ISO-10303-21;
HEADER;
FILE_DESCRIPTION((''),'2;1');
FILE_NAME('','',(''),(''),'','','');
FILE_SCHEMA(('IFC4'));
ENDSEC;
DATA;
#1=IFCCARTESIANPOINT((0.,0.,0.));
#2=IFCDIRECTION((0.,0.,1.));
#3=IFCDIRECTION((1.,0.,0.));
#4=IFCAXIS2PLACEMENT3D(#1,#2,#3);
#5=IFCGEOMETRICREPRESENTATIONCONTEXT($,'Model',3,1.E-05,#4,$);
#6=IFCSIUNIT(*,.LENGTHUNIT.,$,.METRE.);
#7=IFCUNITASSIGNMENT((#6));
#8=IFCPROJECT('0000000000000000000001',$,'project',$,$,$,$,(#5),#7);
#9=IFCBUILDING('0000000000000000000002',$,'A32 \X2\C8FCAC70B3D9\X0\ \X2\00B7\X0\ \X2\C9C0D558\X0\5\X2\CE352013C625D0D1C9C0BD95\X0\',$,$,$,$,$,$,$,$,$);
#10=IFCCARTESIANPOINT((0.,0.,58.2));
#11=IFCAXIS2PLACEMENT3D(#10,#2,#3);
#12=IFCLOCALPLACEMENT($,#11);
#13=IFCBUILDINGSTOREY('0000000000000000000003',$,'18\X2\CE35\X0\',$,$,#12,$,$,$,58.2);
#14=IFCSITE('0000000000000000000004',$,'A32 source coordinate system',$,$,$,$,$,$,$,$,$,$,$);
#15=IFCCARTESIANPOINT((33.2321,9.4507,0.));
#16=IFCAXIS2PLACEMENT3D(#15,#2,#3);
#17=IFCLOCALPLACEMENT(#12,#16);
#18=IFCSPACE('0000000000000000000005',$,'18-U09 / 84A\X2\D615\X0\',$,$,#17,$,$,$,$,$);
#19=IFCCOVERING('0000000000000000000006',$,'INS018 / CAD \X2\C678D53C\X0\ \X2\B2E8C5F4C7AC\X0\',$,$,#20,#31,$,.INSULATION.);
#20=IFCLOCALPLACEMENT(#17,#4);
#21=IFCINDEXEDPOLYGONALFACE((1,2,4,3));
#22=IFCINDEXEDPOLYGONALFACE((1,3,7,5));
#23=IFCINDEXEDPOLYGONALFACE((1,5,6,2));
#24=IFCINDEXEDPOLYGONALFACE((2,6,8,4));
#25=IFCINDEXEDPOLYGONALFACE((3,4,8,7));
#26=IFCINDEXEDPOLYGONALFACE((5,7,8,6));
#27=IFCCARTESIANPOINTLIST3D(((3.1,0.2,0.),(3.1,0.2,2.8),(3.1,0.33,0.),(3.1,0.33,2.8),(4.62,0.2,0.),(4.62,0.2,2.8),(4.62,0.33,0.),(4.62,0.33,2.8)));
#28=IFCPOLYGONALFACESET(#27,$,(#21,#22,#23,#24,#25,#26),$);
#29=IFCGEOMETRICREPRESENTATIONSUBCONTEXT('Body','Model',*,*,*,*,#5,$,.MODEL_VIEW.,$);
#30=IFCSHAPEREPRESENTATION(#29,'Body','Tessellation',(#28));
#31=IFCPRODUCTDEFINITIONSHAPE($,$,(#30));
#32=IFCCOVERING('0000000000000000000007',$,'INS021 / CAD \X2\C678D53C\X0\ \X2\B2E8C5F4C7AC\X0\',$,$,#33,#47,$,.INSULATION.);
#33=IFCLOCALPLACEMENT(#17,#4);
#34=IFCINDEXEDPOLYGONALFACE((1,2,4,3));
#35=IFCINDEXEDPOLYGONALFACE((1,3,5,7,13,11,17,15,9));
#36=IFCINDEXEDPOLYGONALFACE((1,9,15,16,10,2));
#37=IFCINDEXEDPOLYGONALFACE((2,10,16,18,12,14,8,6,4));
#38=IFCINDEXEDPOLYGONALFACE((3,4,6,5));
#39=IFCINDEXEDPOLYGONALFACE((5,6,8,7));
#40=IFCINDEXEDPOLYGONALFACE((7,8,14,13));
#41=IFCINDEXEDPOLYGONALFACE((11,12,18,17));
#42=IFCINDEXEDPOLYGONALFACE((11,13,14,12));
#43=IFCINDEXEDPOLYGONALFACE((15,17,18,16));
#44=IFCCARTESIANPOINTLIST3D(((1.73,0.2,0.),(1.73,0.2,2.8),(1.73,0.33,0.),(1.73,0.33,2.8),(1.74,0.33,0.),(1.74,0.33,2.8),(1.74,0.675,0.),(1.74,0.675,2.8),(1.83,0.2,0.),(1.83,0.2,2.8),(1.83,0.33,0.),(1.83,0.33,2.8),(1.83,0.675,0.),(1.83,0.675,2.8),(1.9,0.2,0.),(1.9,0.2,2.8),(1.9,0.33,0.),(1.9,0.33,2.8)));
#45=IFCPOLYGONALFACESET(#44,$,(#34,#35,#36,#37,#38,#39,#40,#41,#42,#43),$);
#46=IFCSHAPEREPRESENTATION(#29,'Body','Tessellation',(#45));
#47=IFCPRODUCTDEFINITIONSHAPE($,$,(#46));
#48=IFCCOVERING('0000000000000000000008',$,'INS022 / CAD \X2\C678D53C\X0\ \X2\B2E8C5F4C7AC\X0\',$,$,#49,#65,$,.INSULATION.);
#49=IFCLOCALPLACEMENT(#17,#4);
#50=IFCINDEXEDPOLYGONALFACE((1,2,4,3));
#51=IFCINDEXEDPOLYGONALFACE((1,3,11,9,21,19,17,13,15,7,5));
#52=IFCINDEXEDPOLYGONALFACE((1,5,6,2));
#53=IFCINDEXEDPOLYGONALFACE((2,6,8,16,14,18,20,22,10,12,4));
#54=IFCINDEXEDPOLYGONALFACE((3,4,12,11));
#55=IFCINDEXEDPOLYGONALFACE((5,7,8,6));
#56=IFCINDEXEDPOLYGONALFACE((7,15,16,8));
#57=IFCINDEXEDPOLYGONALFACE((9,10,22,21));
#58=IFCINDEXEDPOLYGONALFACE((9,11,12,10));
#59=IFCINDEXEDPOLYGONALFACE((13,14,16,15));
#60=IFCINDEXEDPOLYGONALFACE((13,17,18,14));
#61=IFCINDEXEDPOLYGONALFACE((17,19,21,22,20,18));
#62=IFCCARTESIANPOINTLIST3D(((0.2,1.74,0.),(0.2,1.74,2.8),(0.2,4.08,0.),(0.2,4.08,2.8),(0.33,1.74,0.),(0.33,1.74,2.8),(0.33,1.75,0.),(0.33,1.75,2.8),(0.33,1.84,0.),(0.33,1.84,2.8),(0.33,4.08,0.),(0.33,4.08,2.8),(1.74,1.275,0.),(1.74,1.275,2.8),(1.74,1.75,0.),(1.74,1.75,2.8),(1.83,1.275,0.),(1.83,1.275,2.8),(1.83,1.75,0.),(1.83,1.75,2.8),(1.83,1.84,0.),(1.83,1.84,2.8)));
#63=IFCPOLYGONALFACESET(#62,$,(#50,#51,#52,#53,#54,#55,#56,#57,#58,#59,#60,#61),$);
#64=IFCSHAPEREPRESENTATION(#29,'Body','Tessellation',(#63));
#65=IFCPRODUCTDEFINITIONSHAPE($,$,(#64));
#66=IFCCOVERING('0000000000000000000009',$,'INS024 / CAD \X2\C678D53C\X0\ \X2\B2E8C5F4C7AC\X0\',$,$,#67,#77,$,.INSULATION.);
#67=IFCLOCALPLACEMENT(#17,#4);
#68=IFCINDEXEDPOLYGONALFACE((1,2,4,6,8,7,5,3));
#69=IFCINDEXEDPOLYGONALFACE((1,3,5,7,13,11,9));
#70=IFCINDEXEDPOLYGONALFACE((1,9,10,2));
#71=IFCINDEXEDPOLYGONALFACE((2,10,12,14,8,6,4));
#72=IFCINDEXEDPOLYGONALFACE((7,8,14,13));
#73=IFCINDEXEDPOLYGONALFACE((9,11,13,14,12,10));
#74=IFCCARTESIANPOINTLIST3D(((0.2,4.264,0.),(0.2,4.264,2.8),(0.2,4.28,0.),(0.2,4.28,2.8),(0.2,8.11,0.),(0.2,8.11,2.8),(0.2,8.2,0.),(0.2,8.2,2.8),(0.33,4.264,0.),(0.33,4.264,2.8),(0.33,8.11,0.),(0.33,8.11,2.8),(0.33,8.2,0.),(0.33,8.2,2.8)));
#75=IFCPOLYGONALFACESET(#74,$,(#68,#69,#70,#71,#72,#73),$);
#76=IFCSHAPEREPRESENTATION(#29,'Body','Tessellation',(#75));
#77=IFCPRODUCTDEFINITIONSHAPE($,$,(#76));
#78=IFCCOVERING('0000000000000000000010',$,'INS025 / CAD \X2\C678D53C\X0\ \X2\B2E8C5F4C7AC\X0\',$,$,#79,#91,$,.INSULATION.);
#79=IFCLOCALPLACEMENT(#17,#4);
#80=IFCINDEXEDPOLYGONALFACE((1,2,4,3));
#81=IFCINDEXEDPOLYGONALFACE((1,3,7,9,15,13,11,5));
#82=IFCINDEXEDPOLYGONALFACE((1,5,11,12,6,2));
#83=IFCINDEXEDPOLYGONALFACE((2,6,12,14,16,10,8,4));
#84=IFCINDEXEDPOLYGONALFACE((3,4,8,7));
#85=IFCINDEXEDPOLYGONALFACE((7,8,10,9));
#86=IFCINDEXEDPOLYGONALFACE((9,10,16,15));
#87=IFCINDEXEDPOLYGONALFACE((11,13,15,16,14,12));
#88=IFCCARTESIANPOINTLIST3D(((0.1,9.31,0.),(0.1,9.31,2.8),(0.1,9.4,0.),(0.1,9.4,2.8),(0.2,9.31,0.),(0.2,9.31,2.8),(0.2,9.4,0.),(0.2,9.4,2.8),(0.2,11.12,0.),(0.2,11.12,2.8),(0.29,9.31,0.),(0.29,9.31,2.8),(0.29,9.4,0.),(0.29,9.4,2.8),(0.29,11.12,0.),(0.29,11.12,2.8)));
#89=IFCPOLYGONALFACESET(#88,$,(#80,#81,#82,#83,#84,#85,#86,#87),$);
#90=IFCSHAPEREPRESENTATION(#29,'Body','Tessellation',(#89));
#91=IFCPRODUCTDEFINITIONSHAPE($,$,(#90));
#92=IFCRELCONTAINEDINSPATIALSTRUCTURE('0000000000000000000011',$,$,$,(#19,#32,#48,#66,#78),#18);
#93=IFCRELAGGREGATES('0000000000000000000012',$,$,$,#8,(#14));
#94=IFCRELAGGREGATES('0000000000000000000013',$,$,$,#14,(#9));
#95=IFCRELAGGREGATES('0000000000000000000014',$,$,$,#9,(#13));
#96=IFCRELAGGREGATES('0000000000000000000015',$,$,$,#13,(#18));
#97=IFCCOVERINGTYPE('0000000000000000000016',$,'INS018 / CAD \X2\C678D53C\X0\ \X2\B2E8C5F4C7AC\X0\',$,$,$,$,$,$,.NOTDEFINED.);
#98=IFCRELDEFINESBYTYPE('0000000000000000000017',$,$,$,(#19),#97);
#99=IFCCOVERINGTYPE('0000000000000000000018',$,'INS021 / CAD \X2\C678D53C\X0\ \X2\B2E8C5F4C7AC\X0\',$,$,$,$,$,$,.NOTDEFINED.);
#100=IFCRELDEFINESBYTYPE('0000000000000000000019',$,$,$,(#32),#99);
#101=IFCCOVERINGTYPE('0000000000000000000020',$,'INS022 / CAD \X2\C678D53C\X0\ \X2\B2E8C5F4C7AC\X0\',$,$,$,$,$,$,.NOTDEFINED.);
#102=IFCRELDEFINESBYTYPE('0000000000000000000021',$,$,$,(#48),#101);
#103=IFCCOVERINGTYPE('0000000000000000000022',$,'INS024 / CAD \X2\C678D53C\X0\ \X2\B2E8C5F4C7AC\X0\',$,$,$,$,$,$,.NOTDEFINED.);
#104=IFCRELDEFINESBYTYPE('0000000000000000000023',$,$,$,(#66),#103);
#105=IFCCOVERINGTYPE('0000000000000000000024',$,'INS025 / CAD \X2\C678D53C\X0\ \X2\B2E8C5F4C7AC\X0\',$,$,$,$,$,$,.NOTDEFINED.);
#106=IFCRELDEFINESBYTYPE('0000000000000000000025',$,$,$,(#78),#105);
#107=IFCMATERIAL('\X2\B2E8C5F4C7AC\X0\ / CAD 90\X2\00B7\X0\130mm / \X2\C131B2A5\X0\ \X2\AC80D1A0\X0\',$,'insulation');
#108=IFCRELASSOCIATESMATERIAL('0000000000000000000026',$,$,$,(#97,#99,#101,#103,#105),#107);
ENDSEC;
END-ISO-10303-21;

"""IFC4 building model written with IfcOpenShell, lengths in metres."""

from ifc_helpers import new_model, si_unit, frame, origin, origin_with_axes, place, context, subcontext, project, spatial, polyline, outline, extrude, source, transform, mapped, material, type_object, type_shapes, element, save


model = new_model("IFC4")

# Units and contexts
model_context = context("Model", 3, precision=1e-05, world=origin_with_axes())
body_context = subcontext(model_context, "Body", "Model", "MODEL_VIEW")
ifc_project = project(units=[si_unit("LENGTHUNIT", "METRE")], contexts=[model_context])

# Site, building, storey, space
storey_placement = place(None, frame((0.0, 0.0, 58.2), z_axis=(0.0, 0.0, 1.0), x_axis=(1.0, 0.0, 0.0)))
space_placement = place(storey_placement, frame((33.2321, 9.4507, 0.0), z_axis=(0.0, 0.0, 1.0), x_axis=(1.0, 0.0, 0.0)))
site = spatial("IfcSite", under=ifc_project, Name="A32 source coordinate system")
building = spatial("IfcBuilding", under=site, Name="A32 주거동 · 지하5층–옥탑지붕")
storey = spatial("IfcBuildingStorey", under=building, at=storey_placement, Name="18층", Elevation=58.2)
space = spatial("IfcSpace", under=storey, at=space_placement, Name="18-U09 / 84A형")

# Coverings
ifc_material = material(Name="단열재 / CAD 90·130mm / 성능 검토", Category="insulation")
covering_type_1 = type_object("IfcCoveringType", Name="INS018 / CAD 외피 단열재", PredefinedType="NOTDEFINED", material=ifc_material)
shared_shape_1 = source(origin(), body_context, "Body", "SweptSolid", [
    extrude(outline(polyline([(3.1, 0.33), (4.62, 0.33), (4.62, 0.2), (3.1, 0.2), (3.1, 0.33)])), origin(), (0.0, 0.0, 1.0), 2.8),
])
type_shapes(covering_type_1, [shared_shape_1])
covering_1_placement = place(space_placement, origin_with_axes())
element("IfcCovering", 1, at=covering_1_placement, inside=space, type_object=covering_type_1, Name="INS018 / CAD 외피 단열재", PredefinedType="INSULATION", context=body_context, shape_type="MappedRepresentation", body=[
    mapped(shared_shape_1, transform((0.0, 0.0, 0.0), scale=1.0)),
])
covering_type_2 = type_object("IfcCoveringType", Name="INS021 / CAD 외피 단열재", PredefinedType="NOTDEFINED", material=ifc_material)
shared_shape_2 = source(origin(), body_context, "Body", "SweptSolid", [
    extrude(outline(polyline([(1.83, 0.33), (1.9, 0.33), (1.9, 0.2), (1.83, 0.2), (1.73, 0.2), (1.73, 0.33), (1.74, 0.33), (1.74, 0.675), (1.83, 0.675), (1.83, 0.33)])), origin(), (0.0, 0.0, 1.0), 2.8),
])
type_shapes(covering_type_2, [shared_shape_2])
covering_2_placement = place(space_placement, origin_with_axes())
element("IfcCovering", 2, at=covering_2_placement, inside=space, type_object=covering_type_2, Name="INS021 / CAD 외피 단열재", PredefinedType="INSULATION", context=body_context, shape_type="MappedRepresentation", body=[
    mapped(shared_shape_2, transform((0.0, 0.0, 0.0), scale=1.0)),
])
covering_type_3 = type_object("IfcCoveringType", Name="INS022 / CAD 외피 단열재", PredefinedType="NOTDEFINED", material=ifc_material)
shared_shape_3 = source(origin(), body_context, "Body", "SweptSolid", [
    extrude(outline(polyline([(1.83, 1.84), (1.83, 1.75), (1.83, 1.275), (1.74, 1.275), (1.74, 1.75), (0.33, 1.75), (0.33, 1.74), (0.2, 1.74), (0.2, 4.08), (0.33, 4.08), (0.33, 1.84), (1.83, 1.84)])), origin(), (0.0, 0.0, 1.0), 2.8),
])
type_shapes(covering_type_3, [shared_shape_3])
covering_3_placement = place(space_placement, origin_with_axes())
element("IfcCovering", 3, at=covering_3_placement, inside=space, type_object=covering_type_3, Name="INS022 / CAD 외피 단열재", PredefinedType="INSULATION", context=body_context, shape_type="MappedRepresentation", body=[
    mapped(shared_shape_3, transform((0.0, 0.0, 0.0), scale=1.0)),
])
covering_type_4 = type_object("IfcCoveringType", Name="INS024 / CAD 외피 단열재", PredefinedType="NOTDEFINED", material=ifc_material)
shared_shape_4 = source(origin(), body_context, "Body", "SweptSolid", [
    extrude(outline(polyline([(0.2, 8.11), (0.2, 8.2), (0.33, 8.2), (0.33, 8.11), (0.33, 4.264), (0.2, 4.264), (0.2, 4.28), (0.2, 8.11)])), origin(), (0.0, 0.0, 1.0), 2.8),
])
type_shapes(covering_type_4, [shared_shape_4])
covering_4_placement = place(space_placement, origin_with_axes())
element("IfcCovering", 4, at=covering_4_placement, inside=space, type_object=covering_type_4, Name="INS024 / CAD 외피 단열재", PredefinedType="INSULATION", context=body_context, shape_type="MappedRepresentation", body=[
    mapped(shared_shape_4, transform((0.0, 0.0, 0.0), scale=1.0)),
])
covering_type_5 = type_object("IfcCoveringType", Name="INS025 / CAD 외피 단열재", PredefinedType="NOTDEFINED", material=ifc_material)
shared_shape_5 = source(origin(), body_context, "Body", "SweptSolid", [
    extrude(outline(polyline([(0.2, 9.4), (0.2, 11.12), (0.29, 11.12), (0.29, 9.4), (0.29, 9.31), (0.2, 9.31), (0.1, 9.31), (0.1, 9.4), (0.2, 9.4)])), origin(), (0.0, 0.0, 1.0), 2.8),
])
type_shapes(covering_type_5, [shared_shape_5])
covering_5_placement = place(space_placement, origin_with_axes())
element("IfcCovering", 5, at=covering_5_placement, inside=space, type_object=covering_type_5, Name="INS025 / CAD 외피 단열재", PredefinedType="INSULATION", context=body_context, shape_type="MappedRepresentation", body=[
    mapped(shared_shape_5, transform((0.0, 0.0, 0.0), scale=1.0)),
])

save(model, "model.ifc")
